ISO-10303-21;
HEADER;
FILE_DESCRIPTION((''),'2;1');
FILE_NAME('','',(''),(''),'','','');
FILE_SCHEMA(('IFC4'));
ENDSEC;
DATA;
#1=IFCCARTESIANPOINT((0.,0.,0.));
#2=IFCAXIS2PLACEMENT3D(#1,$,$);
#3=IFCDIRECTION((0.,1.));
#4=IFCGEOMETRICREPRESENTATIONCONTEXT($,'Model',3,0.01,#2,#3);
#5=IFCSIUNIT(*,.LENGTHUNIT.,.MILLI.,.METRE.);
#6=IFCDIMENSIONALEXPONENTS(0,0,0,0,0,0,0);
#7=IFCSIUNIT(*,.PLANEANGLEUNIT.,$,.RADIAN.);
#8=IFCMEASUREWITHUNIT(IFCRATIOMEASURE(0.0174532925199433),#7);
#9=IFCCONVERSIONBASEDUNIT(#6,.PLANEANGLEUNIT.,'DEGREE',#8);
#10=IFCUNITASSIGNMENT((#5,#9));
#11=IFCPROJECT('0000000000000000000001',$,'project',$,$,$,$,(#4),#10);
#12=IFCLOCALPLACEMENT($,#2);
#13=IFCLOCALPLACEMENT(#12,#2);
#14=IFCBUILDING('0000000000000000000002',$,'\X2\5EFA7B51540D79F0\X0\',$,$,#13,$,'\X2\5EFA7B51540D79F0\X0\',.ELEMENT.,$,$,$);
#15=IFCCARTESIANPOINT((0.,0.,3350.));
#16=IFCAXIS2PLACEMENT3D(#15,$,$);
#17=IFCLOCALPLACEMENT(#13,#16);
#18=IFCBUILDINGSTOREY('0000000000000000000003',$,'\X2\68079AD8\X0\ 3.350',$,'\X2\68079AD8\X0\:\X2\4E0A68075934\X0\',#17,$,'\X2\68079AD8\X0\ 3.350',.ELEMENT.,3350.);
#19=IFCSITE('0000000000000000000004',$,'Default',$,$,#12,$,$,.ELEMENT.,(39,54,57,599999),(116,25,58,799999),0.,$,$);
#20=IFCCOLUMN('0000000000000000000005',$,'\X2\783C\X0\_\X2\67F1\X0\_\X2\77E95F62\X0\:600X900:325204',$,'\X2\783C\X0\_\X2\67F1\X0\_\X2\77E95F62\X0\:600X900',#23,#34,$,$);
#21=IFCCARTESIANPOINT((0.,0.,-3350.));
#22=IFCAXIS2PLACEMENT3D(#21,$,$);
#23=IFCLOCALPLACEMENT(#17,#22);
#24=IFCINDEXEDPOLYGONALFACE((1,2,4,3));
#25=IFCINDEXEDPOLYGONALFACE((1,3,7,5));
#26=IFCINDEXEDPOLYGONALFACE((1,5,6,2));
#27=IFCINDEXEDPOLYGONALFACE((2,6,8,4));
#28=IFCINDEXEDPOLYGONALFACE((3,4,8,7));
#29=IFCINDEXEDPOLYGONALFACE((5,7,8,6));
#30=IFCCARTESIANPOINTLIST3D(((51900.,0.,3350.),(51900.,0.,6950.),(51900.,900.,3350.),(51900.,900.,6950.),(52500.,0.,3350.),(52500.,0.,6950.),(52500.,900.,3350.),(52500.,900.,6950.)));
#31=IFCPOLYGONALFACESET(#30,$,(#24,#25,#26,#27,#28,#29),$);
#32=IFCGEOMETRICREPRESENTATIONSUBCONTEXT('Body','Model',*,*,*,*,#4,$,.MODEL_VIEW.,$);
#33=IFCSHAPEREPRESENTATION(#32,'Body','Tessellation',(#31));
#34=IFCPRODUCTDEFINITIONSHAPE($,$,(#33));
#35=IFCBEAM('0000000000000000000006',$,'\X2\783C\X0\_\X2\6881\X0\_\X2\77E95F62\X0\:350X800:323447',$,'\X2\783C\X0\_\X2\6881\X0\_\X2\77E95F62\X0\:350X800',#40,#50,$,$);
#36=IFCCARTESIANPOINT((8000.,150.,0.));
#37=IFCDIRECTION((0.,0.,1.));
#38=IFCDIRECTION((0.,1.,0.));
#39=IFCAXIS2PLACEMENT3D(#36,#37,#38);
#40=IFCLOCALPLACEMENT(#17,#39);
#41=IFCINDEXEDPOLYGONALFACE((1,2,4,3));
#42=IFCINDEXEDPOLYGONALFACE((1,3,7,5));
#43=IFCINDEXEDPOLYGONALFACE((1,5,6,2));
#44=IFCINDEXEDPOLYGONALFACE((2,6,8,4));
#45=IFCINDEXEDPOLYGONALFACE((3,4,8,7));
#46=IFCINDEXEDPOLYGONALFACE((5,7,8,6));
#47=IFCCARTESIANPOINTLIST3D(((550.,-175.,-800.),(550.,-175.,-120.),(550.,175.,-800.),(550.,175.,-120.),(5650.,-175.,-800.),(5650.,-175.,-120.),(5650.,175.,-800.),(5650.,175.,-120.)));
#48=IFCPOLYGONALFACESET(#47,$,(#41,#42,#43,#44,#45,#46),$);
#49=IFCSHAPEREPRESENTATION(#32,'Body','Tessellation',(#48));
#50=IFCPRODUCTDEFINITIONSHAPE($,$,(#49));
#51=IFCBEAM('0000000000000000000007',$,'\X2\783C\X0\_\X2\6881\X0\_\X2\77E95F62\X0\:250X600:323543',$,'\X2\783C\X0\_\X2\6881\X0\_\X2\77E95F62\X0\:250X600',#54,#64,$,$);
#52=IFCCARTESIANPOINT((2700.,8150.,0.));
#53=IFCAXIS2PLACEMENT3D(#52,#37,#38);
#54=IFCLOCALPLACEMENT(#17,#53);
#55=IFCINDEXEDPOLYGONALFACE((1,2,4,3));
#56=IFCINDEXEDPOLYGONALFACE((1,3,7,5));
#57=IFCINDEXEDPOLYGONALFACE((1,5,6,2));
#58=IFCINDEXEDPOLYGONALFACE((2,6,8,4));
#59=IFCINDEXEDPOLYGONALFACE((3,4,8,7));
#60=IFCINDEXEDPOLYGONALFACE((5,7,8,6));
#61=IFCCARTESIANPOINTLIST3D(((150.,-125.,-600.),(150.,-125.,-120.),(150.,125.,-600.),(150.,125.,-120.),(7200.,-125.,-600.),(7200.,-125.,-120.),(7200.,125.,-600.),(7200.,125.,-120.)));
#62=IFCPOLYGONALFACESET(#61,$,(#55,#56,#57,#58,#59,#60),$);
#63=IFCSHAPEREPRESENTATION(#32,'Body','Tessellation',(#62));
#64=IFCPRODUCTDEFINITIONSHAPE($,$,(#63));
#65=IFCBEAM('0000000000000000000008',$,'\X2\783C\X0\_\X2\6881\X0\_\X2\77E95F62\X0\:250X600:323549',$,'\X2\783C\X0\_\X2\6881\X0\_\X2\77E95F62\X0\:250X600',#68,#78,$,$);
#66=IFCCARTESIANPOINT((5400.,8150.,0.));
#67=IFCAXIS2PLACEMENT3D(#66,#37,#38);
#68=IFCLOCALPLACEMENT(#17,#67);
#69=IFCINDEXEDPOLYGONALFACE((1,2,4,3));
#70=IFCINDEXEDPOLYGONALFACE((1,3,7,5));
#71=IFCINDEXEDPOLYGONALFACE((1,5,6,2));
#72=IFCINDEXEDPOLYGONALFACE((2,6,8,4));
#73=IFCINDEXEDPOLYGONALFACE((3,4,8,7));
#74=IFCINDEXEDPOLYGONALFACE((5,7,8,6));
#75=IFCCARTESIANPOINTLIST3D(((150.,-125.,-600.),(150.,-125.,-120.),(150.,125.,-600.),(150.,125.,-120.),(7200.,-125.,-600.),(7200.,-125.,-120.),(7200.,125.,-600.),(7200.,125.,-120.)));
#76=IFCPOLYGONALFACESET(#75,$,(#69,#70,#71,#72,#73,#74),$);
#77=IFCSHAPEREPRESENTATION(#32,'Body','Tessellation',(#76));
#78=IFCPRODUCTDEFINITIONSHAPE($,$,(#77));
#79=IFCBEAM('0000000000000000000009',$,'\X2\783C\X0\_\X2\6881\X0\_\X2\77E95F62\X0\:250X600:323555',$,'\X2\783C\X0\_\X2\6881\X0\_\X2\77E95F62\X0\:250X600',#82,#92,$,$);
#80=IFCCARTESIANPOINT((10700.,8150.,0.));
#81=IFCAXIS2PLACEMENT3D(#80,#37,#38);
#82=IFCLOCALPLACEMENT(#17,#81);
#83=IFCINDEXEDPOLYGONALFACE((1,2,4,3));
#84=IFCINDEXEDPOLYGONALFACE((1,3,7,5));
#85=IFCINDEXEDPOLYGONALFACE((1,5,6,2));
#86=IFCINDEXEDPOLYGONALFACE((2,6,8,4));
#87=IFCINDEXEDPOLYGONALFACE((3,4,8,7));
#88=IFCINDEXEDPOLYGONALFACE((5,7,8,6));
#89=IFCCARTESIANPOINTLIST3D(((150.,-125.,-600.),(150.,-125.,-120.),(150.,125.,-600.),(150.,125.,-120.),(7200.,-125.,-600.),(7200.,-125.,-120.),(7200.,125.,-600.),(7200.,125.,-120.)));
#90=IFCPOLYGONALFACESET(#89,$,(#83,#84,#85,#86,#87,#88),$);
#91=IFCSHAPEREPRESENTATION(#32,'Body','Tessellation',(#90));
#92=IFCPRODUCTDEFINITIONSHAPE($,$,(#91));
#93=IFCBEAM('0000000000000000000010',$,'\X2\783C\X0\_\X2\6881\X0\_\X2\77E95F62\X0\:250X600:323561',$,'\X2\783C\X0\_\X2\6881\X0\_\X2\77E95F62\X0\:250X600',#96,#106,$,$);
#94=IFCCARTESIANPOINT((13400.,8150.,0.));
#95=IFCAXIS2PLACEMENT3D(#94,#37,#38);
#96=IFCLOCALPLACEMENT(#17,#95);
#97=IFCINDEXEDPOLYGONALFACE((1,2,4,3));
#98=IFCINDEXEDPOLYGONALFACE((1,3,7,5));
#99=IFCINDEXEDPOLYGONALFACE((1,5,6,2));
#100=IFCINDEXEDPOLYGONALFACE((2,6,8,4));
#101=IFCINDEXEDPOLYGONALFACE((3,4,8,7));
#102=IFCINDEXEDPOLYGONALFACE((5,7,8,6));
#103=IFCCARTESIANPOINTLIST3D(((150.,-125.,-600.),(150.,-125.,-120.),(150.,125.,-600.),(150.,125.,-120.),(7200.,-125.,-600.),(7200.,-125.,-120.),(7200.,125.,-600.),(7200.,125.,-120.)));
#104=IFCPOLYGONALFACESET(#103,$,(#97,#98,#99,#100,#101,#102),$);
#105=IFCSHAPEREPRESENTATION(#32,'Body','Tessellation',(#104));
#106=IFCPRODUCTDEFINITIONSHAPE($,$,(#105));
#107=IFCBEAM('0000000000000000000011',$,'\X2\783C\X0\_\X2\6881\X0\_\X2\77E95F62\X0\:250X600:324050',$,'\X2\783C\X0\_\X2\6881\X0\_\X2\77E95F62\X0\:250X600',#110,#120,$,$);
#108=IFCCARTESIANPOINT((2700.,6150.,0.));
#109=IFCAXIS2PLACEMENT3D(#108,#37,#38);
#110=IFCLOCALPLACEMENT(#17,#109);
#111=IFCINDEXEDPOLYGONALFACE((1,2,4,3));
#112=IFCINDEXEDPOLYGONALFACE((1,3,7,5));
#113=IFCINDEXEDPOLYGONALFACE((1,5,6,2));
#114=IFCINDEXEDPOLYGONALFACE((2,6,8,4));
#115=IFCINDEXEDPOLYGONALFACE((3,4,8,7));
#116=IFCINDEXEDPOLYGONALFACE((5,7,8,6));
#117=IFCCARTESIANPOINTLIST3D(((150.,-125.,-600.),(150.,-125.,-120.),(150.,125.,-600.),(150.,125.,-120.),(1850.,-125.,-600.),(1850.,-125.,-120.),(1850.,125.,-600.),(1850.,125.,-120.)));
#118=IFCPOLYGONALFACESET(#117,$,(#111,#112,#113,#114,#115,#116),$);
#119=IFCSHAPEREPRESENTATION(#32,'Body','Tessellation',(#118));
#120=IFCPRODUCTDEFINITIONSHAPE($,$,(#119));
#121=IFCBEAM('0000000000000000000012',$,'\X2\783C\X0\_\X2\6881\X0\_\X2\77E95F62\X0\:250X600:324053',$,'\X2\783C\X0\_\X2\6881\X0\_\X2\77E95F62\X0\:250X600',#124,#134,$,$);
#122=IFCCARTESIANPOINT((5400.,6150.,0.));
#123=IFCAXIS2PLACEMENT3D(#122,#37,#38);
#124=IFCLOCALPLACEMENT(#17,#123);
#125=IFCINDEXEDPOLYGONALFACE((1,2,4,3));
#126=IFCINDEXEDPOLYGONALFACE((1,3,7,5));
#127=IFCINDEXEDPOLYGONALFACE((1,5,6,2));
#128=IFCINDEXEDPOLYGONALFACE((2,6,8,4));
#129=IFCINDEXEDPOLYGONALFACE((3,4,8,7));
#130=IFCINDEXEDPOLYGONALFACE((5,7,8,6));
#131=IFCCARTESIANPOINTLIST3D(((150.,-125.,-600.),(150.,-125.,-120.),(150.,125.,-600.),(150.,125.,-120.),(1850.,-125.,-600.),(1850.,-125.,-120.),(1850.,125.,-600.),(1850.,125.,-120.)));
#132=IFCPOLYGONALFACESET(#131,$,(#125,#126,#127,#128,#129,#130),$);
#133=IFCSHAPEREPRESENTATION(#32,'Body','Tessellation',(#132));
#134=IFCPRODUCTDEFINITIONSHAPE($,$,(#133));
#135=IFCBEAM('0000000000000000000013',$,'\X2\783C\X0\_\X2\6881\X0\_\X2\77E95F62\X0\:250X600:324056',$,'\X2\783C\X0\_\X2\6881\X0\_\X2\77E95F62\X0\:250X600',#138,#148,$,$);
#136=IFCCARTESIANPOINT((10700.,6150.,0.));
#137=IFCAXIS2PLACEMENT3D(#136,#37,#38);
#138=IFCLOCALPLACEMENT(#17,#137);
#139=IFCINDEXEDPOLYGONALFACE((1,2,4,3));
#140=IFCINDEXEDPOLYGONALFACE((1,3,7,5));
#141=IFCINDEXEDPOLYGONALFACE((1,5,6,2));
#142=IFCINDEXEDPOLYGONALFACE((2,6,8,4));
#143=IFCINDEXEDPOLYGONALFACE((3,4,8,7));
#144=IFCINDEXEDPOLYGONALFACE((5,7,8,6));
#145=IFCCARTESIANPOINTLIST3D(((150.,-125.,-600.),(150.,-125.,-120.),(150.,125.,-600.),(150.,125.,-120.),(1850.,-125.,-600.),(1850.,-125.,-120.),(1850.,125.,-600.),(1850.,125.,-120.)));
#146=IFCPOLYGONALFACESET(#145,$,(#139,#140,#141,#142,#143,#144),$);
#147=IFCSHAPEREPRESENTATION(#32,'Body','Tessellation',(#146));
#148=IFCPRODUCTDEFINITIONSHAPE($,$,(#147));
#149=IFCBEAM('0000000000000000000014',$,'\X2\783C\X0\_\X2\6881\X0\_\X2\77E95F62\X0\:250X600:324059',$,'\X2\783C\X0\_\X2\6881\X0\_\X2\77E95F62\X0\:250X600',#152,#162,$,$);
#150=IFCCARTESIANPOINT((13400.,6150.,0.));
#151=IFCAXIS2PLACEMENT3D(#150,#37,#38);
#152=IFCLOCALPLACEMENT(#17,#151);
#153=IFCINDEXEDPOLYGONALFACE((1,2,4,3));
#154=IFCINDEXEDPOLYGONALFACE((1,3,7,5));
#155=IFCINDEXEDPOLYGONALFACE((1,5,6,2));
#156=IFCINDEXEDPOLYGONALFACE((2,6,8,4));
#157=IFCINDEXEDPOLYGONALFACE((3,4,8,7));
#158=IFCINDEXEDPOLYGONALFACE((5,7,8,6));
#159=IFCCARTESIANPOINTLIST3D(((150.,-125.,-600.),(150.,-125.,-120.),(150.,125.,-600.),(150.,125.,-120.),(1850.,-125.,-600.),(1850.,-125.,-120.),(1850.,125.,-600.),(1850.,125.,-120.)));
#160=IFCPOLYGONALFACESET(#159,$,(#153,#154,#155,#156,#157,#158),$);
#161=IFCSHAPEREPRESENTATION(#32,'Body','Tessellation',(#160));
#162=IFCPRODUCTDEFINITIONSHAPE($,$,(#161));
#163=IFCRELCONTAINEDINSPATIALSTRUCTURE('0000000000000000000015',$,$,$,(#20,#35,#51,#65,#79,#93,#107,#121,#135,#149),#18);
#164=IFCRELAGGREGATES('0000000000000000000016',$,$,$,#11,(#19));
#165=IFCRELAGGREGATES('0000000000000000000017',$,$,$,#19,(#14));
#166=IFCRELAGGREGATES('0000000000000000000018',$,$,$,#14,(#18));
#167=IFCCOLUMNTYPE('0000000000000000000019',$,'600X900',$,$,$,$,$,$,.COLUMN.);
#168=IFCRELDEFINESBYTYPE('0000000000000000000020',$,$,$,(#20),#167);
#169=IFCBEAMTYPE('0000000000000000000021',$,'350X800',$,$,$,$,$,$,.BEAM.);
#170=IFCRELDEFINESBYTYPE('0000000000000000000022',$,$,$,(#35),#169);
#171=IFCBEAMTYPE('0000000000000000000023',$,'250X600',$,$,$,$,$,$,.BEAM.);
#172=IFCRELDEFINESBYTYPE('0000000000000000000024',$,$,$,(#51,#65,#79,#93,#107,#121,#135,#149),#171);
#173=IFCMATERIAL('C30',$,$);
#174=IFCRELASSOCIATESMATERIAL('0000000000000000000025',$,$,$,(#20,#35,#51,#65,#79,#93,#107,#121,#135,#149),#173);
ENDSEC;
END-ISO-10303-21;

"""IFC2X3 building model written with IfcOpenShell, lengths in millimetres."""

from ifc_helpers import new_model, entity, si_unit, converted_unit, direction, frame, frame_2d, origin, origin_2d_with_axis, place, context, subcontext, project, spatial, rectangle, extrude, source, transform, mapped, material, type_object, type_shapes, element, save


model = new_model("IFC2X3")

# Units and contexts
model_context = context("Model", 3, precision=0.01, world=origin(), true_north=direction((0.0, 1.0)))
body_context = subcontext(model_context, "Body", "Model", "MODEL_VIEW")
ifc_project = project(units=[si_unit("LENGTHUNIT", "METRE", prefix="MILLI"), converted_unit("PLANEANGLEUNIT", "DEGREE", entity("IfcRatioMeasure", 0.0174532925199433), si_unit("PLANEANGLEUNIT", "RADIAN"), dimensions=[0, 0, 0, 0, 0, 0, 0])], contexts=[model_context])

# Site, building, storey
site_placement = place(None, origin())
site = spatial("IfcSite", under=ifc_project, at=site_placement, Name="Default", CompositionType="ELEMENT", RefLatitude=(39, 54, 57, 599999), RefLongitude=(116, 25, 58, 799999), RefElevation=0.0)
building_placement = place(site_placement, origin())
building = spatial("IfcBuilding", under=site, at=building_placement, Name="建筑名称", LongName="建筑名称", CompositionType="ELEMENT")
storey_placement = place(building_placement, frame((0.0, 0.0, 3350.0)))
storey = spatial("IfcBuildingStorey", under=building, at=storey_placement, Name="标高 3.350", ObjectType="标高:上标头", LongName="标高 3.350", CompositionType="ELEMENT", Elevation=3350.0)

# Column
ifc_material = material(Name="C30")
column_type = type_object("IfcColumnType", Name="600X900", PredefinedType="COLUMN")
shared_shape = source(origin(), body_context, "Body", "SweptSolid", [
    extrude(rectangle(XDim=900.0, YDim=600.0, at=origin_2d_with_axis()), frame((52200.0, 450.0, 3350.0), z_axis=(0.0, 0.0, 1.0), x_axis=(0.0, -1.0, 0.0)), (0.0, 0.0, 1.0), 3600.0),
])
type_shapes(column_type, [shared_shape])
column_placement = place(storey_placement, frame((0.0, 0.0, -3350.0)))
element("IfcColumn", 1, at=column_placement, inside=storey, type_object=column_type, material=ifc_material, Name="砼_柱_矩形:600X900:325204", ObjectType="砼_柱_矩形:600X900", context=body_context, shape_type="MappedRepresentation", body=[
    mapped(shared_shape, transform((0.0, 0.0, 0.0), scale=1.0)),
])

# Beams
beam_type_1 = type_object("IfcBeamType", Name="350X800", PredefinedType="BEAM")
beam_1_placement = place(storey_placement, frame((8000.0, 150.0, 0.0), z_axis=(0.0, 0.0, 1.0), x_axis=(0.0, 1.0, 0.0)))
element("IfcBeam", 2, at=beam_1_placement, inside=storey, type_object=beam_type_1, material=ifc_material, Name="砼_梁_矩形:350X800:323447", ObjectType="砼_梁_矩形:350X800", context=body_context, shape_type="SweptSolid", body=[
    extrude(rectangle(XDim=680.0, YDim=350.0, at=frame_2d((0.0, 0.0), x_axis=(1.0, 0.0))), frame((550.0, 0.0, -460.0), z_axis=(1.0, 0.0, 0.0), x_axis=(0.0, 0.0, -1.0)), (0.0, 0.0, 1.0), 5100.0),
])
beam_type_2 = type_object("IfcBeamType", Name="250X600", PredefinedType="BEAM")
beam_2_placement = place(storey_placement, frame((2700.0, 8150.0, 0.0), z_axis=(0.0, 0.0, 1.0), x_axis=(0.0, 1.0, 0.0)))
element("IfcBeam", 3, at=beam_2_placement, inside=storey, type_object=beam_type_2, material=ifc_material, Name="砼_梁_矩形:250X600:323543", ObjectType="砼_梁_矩形:250X600", context=body_context, shape_type="SweptSolid", body=[
    extrude(rectangle(XDim=480.0, YDim=250.0, at=frame_2d((0.0, 0.0), x_axis=(1.0, 0.0))), frame((150.0, 0.0, -360.0), z_axis=(1.0, 0.0, 0.0), x_axis=(0.0, 0.0, -1.0)), (0.0, 0.0, 1.0), 7050.0),
])
beam_3_placement = place(storey_placement, frame((5400.0, 8150.0, 0.0), z_axis=(0.0, 0.0, 1.0), x_axis=(0.0, 1.0, 0.0)))
element("IfcBeam", 4, at=beam_3_placement, inside=storey, type_object=beam_type_2, material=ifc_material, Name="砼_梁_矩形:250X600:323549", ObjectType="砼_梁_矩形:250X600", context=body_context, shape_type="SweptSolid", body=[
    extrude(rectangle(XDim=480.0, YDim=250.0, at=frame_2d((0.0, 0.0), x_axis=(1.0, 0.0))), frame((150.0, 0.0, -360.0), z_axis=(1.0, 0.0, 0.0), x_axis=(0.0, 0.0, -1.0)), (0.0, 0.0, 1.0), 7050.0),
])
beam_4_placement = place(storey_placement, frame((10700.0, 8150.0, 0.0), z_axis=(0.0, 0.0, 1.0), x_axis=(0.0, 1.0, 0.0)))
element("IfcBeam", 5, at=beam_4_placement, inside=storey, type_object=beam_type_2, material=ifc_material, Name="砼_梁_矩形:250X600:323555", ObjectType="砼_梁_矩形:250X600", context=body_context, shape_type="SweptSolid", body=[
    extrude(rectangle(XDim=480.0, YDim=250.0, at=frame_2d((0.0, 0.0), x_axis=(1.0, 0.0))), frame((150.0, 0.0, -360.0), z_axis=(1.0, 0.0, 0.0), x_axis=(0.0, 0.0, -1.0)), (0.0, 0.0, 1.0), 7050.0),
])
beam_5_placement = place(storey_placement, frame((13400.0, 8150.0, 0.0), z_axis=(0.0, 0.0, 1.0), x_axis=(0.0, 1.0, 0.0)))
element("IfcBeam", 6, at=beam_5_placement, inside=storey, type_object=beam_type_2, material=ifc_material, Name="砼_梁_矩形:250X600:323561", ObjectType="砼_梁_矩形:250X600", context=body_context, shape_type="SweptSolid", body=[
    extrude(rectangle(XDim=480.0, YDim=250.0, at=frame_2d((0.0, 0.0), x_axis=(1.0, 0.0))), frame((150.0, 0.0, -360.0), z_axis=(1.0, 0.0, 0.0), x_axis=(0.0, 0.0, -1.0)), (0.0, 0.0, 1.0), 7050.0),
])
beam_6_placement = place(storey_placement, frame((2700.0, 6150.0, 0.0), z_axis=(0.0, 0.0, 1.0), x_axis=(0.0, 1.0, 0.0)))
element("IfcBeam", 7, at=beam_6_placement, inside=storey, type_object=beam_type_2, material=ifc_material, Name="砼_梁_矩形:250X600:324050", ObjectType="砼_梁_矩形:250X600", context=body_context, shape_type="SweptSolid", body=[
    extrude(rectangle(XDim=480.0, YDim=250.0, at=frame_2d((0.0, 0.0), x_axis=(1.0, 0.0))), frame((150.0, 0.0, -360.0), z_axis=(1.0, 0.0, 0.0), x_axis=(0.0, 0.0, -1.0)), (0.0, 0.0, 1.0), 1700.0),
])
beam_7_placement = place(storey_placement, frame((5400.0, 6150.0, 0.0), z_axis=(0.0, 0.0, 1.0), x_axis=(0.0, 1.0, 0.0)))
element("IfcBeam", 8, at=beam_7_placement, inside=storey, type_object=beam_type_2, material=ifc_material, Name="砼_梁_矩形:250X600:324053", ObjectType="砼_梁_矩形:250X600", context=body_context, shape_type="SweptSolid", body=[
    extrude(rectangle(XDim=480.0, YDim=250.0, at=frame_2d((0.0, 0.0), x_axis=(1.0, 0.0))), frame((150.0, 0.0, -360.0), z_axis=(1.0, 0.0, 0.0), x_axis=(0.0, 0.0, -1.0)), (0.0, 0.0, 1.0), 1700.0),
])
for number, where, z_axis, x_axis, name in (
    (9, (10700.0, 6150.0, 0.0), (0.0, 0.0, 1.0), (0.0, 1.0, 0.0), "砼_梁_矩形:250X600:324056"),
    (10, (13400.0, 6150.0, 0.0), (0.0, 0.0, 1.0), (0.0, 1.0, 0.0), "砼_梁_矩形:250X600:324059"),
):
    element("IfcBeam", number, at=place(storey_placement, frame(where, z_axis=z_axis, x_axis=x_axis)), inside=storey, type_object=beam_type_2, material=ifc_material, Name=name, ObjectType="砼_梁_矩形:250X600", context=body_context, shape_type="SweptSolid", body=[
        extrude(rectangle(XDim=480.0, YDim=250.0, at=frame_2d((0.0, 0.0), x_axis=(1.0, 0.0))), frame((150.0, 0.0, -360.0), z_axis=(1.0, 0.0, 0.0), x_axis=(0.0, 0.0, -1.0)), (0.0, 0.0, 1.0), 1700.0),
    ])

save(model, "model.ifc")
